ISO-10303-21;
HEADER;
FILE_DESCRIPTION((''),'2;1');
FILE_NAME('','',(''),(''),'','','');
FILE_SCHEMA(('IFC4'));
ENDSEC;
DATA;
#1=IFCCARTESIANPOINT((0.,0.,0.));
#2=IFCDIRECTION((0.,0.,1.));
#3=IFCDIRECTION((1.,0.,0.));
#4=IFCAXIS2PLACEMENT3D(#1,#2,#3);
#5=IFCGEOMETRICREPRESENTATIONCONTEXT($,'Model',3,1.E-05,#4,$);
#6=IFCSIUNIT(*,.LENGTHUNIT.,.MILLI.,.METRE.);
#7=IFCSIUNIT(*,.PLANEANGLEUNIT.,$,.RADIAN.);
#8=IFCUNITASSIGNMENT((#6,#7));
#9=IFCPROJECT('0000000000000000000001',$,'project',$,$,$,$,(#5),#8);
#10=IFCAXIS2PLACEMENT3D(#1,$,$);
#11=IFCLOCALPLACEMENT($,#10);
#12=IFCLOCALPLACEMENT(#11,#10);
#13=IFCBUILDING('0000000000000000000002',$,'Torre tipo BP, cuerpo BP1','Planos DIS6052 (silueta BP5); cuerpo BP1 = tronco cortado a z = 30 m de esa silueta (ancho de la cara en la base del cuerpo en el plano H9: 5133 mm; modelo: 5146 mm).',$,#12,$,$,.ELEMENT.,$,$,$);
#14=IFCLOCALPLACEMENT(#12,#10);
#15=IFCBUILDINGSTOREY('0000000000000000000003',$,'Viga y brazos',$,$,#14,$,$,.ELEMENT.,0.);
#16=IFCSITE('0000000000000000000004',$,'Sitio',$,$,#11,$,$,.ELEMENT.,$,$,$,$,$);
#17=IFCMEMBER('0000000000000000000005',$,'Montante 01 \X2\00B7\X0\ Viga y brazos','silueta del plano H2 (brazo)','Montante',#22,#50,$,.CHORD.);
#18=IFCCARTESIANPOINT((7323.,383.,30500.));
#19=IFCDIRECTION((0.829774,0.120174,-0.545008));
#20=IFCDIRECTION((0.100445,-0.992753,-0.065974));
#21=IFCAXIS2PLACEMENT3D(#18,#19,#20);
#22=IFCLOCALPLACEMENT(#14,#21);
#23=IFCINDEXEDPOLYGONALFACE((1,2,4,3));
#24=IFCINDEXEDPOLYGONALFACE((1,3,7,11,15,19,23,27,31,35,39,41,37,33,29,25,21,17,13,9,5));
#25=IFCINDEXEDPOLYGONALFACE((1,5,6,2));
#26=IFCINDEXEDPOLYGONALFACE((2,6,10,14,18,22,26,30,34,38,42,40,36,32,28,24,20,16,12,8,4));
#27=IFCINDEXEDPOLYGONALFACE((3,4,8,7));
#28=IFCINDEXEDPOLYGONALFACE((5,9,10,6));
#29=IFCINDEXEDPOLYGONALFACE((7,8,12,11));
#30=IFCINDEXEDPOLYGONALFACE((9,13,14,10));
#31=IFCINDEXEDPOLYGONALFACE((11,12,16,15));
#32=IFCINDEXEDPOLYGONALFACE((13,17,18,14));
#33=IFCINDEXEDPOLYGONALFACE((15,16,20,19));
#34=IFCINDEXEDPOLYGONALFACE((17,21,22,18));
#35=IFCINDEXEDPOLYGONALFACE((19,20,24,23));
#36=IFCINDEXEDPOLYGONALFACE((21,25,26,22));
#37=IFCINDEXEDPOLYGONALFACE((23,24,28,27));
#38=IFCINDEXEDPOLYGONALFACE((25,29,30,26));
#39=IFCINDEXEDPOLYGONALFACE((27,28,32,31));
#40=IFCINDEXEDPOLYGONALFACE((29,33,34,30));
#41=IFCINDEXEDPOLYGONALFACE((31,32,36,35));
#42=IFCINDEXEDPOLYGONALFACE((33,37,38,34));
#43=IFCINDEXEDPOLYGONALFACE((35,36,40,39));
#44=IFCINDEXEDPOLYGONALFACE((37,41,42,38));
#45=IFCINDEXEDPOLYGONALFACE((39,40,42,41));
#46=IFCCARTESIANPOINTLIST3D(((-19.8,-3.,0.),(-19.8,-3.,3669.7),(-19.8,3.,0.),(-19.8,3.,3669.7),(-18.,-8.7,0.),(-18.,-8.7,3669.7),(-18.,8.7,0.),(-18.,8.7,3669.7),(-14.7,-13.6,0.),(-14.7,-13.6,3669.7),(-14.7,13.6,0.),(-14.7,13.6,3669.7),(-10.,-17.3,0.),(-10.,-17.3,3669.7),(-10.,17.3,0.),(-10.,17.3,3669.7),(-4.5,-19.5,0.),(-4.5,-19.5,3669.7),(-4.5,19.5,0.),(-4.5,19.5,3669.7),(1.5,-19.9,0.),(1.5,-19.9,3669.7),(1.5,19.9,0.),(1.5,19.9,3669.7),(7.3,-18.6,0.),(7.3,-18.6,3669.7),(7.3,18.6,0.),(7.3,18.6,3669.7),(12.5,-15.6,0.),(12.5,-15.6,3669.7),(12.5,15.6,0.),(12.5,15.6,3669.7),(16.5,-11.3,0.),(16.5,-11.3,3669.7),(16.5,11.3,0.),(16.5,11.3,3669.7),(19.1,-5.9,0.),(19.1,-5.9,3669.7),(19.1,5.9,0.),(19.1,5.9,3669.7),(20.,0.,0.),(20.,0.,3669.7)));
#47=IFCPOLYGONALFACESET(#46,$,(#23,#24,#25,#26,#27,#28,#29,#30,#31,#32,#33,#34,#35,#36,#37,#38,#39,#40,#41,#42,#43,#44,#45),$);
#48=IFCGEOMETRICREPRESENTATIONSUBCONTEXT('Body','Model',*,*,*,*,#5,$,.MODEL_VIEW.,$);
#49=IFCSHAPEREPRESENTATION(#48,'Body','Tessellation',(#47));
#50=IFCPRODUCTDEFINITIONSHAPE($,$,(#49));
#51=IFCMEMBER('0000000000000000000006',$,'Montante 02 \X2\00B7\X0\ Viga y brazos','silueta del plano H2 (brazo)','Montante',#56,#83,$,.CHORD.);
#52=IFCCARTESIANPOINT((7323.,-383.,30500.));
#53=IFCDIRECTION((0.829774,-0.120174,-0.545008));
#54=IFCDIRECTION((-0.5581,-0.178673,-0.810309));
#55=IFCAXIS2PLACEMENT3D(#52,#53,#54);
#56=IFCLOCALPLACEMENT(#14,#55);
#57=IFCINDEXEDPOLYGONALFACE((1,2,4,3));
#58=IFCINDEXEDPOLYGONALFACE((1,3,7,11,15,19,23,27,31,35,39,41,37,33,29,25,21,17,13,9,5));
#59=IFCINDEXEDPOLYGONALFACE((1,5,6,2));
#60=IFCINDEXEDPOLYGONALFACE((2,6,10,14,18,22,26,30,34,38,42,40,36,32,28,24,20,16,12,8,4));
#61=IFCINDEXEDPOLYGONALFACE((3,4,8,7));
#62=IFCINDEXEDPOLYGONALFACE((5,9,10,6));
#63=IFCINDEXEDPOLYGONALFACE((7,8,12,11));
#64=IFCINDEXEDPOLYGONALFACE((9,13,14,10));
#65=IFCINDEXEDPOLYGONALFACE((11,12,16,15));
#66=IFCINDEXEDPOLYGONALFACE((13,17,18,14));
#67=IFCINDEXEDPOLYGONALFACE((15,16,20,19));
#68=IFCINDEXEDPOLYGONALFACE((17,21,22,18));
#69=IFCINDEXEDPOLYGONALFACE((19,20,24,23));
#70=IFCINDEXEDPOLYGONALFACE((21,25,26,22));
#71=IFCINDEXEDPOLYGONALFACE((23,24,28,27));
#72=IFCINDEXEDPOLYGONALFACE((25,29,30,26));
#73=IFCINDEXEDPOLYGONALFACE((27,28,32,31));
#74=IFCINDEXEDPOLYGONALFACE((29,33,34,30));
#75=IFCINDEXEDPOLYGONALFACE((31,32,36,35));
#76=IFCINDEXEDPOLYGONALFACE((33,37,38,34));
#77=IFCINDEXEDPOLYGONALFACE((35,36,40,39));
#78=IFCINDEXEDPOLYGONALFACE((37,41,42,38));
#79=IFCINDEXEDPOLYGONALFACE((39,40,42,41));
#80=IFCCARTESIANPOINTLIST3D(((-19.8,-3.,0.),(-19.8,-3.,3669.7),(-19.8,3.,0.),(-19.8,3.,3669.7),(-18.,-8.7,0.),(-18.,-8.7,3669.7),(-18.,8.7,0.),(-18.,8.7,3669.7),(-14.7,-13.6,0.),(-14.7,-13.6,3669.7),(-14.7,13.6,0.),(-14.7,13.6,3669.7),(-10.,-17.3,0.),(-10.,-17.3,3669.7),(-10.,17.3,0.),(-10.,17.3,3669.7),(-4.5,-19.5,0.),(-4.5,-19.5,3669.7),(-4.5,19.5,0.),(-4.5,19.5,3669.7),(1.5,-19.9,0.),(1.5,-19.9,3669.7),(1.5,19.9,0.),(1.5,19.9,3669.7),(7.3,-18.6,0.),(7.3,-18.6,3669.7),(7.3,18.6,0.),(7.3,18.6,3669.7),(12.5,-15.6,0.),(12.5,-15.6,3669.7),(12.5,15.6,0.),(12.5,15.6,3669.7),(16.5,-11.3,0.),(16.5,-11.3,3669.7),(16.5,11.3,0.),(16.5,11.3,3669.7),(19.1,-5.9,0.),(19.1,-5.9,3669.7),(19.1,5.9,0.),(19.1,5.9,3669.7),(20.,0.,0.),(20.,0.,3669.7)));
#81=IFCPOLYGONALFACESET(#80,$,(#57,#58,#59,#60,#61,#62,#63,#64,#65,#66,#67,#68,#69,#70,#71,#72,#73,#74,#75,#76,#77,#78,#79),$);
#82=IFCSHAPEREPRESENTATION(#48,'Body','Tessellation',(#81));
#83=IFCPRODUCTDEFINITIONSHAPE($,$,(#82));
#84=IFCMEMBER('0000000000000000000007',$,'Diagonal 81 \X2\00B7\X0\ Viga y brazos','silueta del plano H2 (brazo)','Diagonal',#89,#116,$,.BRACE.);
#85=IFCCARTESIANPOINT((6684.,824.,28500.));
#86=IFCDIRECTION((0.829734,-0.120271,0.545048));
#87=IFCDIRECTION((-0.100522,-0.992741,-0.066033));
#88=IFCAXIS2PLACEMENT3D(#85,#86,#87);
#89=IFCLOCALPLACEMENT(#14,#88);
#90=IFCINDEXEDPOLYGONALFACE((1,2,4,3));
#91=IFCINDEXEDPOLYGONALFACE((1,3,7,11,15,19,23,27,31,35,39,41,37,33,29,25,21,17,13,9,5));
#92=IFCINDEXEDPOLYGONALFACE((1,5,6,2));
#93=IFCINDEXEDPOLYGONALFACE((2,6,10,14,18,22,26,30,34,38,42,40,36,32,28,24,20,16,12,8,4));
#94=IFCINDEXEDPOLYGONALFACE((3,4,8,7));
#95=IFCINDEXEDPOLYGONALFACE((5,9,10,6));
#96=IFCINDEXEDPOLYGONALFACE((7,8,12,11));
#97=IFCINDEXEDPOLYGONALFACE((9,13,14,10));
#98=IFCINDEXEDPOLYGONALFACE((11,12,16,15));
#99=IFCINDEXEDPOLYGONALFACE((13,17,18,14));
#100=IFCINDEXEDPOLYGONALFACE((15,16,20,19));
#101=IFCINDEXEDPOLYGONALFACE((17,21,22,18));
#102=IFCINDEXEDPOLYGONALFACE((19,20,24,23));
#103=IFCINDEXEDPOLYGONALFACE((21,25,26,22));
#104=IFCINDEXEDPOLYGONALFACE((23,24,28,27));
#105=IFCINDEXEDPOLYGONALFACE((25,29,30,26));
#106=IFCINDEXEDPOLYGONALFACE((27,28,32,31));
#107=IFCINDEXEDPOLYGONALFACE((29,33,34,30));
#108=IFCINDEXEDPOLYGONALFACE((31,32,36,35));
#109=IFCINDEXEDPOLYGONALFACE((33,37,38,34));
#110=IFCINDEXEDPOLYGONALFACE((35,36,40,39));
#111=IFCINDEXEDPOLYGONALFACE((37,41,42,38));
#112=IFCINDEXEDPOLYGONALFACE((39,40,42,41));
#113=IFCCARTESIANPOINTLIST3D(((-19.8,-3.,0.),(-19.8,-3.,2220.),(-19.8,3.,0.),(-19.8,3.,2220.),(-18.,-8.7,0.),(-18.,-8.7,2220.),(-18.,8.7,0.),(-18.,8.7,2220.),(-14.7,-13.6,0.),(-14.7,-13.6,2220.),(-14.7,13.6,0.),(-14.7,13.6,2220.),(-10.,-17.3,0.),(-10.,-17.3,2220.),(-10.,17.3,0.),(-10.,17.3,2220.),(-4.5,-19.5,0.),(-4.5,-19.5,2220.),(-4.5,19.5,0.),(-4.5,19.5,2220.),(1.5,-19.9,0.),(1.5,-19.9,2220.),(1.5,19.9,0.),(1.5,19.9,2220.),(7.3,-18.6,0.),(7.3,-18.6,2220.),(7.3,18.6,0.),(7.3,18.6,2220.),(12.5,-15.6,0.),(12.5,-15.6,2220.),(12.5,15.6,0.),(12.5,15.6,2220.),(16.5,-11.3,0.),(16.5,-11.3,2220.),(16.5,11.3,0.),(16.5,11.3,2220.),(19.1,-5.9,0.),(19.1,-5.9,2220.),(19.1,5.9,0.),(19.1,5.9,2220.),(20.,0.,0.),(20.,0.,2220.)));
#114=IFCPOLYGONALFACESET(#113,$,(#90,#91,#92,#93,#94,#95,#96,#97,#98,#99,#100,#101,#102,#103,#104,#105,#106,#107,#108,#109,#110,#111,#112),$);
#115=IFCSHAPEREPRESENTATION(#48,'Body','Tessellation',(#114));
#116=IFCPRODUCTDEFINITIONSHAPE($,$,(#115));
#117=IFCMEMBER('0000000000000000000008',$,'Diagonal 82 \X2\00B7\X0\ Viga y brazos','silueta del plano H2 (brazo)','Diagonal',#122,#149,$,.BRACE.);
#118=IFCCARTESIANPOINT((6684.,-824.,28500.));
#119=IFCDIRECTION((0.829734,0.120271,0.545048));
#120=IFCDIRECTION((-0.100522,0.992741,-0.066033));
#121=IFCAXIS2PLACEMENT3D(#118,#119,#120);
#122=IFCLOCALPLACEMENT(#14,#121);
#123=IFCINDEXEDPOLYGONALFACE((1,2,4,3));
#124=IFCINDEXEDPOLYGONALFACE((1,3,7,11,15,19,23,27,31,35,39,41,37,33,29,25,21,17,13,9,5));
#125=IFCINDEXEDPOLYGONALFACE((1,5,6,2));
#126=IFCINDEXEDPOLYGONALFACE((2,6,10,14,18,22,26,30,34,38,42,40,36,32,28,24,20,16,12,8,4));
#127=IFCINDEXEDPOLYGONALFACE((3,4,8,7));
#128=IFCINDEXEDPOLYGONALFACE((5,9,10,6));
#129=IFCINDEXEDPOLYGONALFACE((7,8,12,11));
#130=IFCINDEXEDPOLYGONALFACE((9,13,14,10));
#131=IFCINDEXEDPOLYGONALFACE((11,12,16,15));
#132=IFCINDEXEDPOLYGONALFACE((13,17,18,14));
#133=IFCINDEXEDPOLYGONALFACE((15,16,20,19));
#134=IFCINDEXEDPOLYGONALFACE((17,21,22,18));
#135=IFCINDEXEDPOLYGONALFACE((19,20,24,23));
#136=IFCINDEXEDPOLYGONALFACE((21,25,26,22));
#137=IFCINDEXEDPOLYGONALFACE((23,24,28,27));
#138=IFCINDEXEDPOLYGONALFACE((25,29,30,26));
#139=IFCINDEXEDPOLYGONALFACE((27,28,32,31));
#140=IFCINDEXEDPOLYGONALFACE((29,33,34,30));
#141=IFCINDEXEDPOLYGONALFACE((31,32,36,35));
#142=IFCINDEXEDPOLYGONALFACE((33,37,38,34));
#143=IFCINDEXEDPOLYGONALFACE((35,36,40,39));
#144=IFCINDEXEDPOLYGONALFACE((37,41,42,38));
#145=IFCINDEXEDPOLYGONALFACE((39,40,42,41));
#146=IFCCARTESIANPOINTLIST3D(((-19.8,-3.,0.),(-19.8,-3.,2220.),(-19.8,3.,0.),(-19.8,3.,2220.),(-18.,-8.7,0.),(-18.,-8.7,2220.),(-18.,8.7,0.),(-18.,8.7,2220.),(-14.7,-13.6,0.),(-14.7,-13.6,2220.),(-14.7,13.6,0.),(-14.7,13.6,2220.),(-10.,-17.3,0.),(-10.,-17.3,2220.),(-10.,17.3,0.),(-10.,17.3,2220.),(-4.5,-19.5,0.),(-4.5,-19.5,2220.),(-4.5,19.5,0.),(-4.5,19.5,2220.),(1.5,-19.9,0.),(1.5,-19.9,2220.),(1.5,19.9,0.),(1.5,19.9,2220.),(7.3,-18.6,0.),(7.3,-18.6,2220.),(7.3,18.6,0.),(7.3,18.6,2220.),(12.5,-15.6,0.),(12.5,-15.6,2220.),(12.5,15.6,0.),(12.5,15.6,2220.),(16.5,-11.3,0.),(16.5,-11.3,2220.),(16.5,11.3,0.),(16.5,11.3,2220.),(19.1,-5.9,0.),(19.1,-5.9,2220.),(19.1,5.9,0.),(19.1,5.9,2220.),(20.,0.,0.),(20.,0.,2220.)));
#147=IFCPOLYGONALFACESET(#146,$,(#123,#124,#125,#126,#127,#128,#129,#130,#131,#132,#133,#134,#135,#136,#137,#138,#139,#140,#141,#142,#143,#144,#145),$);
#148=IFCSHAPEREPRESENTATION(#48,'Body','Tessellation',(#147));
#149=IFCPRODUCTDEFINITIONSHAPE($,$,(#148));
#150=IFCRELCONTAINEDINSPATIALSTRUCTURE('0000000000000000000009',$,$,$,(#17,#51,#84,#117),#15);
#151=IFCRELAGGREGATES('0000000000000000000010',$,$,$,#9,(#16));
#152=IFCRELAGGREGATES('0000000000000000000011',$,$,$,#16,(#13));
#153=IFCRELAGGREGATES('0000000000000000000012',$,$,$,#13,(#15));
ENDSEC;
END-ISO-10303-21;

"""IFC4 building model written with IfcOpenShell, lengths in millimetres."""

from ifc_helpers import new_model, si_unit, frame, origin, origin_with_axes, place, context, subcontext, project, spatial, circle, extrude, element, save


model = new_model("IFC4")

# Units and contexts
model_context = context("Model", 3, precision=1e-05, world=origin_with_axes())
body_context = subcontext(model_context, "Body", "Model", "MODEL_VIEW")
ifc_project = project(units=[si_unit("LENGTHUNIT", "METRE", prefix="MILLI"), si_unit("PLANEANGLEUNIT", "RADIAN")], contexts=[model_context])

# Site, building, storey
site_placement = place(None, origin())
site = spatial("IfcSite", under=ifc_project, at=site_placement, Name="Sitio", CompositionType="ELEMENT")
building_placement = place(site_placement, origin())
building = spatial("IfcBuilding", under=site, at=building_placement, Name="Torre tipo BP, cuerpo BP1", Description="Planos DIS6052 (silueta BP5); cuerpo BP1 = tronco cortado a z = 30 m de esa silueta (ancho de la cara en la base del cuerpo en el plano H9: 5133 mm; modelo: 5146 mm).", CompositionType="ELEMENT")
storey_placement = place(building_placement, origin())
storey = spatial("IfcBuildingStorey", under=building, at=storey_placement, Name="Viga y brazos", CompositionType="ELEMENT", Elevation=0.0)

# Members
for number, where, z_axis, x_axis, name in (
    (1, (7323.0, 383.0, 30500.0), (0.829774, 0.120174, -0.545008), (0.100445, -0.992753, -0.065974), "Montante 01 · Viga y brazos"),
    (2, (7323.0, -383.0, 30500.0), (0.829774, -0.120174, -0.545008), (-0.5581, -0.178673, -0.810309), "Montante 02 · Viga y brazos"),
):
    element("IfcMember", number, at=place(storey_placement, frame(where, z_axis=z_axis, x_axis=x_axis)), inside=storey, Name=name, Description="silueta del plano H2 (brazo)", ObjectType="Montante", PredefinedType="CHORD", context=body_context, shape_type="SweptSolid", body=[
        extrude(circle(Radius=20.0), None, (0.0, 0.0, 1.0), 3669.7),
    ])
for number, where, z_axis, x_axis, name in (
    (3, (6684.0, 824.0, 28500.0), (0.829734, -0.120271, 0.545048), (-0.100522, -0.992741, -0.066033), "Diagonal 81 · Viga y brazos"),
    (4, (6684.0, -824.0, 28500.0), (0.829734, 0.120271, 0.545048), (-0.100522, 0.992741, -0.066033), "Diagonal 82 · Viga y brazos"),
):
    element("IfcMember", number, at=place(storey_placement, frame(where, z_axis=z_axis, x_axis=x_axis)), inside=storey, Name=name, Description="silueta del plano H2 (brazo)", ObjectType="Diagonal", PredefinedType="BRACE", context=body_context, shape_type="SweptSolid", body=[
        extrude(circle(Radius=20.0), None, (0.0, 0.0, 1.0), 2220.0),
    ])

save(model, "model.ifc")
